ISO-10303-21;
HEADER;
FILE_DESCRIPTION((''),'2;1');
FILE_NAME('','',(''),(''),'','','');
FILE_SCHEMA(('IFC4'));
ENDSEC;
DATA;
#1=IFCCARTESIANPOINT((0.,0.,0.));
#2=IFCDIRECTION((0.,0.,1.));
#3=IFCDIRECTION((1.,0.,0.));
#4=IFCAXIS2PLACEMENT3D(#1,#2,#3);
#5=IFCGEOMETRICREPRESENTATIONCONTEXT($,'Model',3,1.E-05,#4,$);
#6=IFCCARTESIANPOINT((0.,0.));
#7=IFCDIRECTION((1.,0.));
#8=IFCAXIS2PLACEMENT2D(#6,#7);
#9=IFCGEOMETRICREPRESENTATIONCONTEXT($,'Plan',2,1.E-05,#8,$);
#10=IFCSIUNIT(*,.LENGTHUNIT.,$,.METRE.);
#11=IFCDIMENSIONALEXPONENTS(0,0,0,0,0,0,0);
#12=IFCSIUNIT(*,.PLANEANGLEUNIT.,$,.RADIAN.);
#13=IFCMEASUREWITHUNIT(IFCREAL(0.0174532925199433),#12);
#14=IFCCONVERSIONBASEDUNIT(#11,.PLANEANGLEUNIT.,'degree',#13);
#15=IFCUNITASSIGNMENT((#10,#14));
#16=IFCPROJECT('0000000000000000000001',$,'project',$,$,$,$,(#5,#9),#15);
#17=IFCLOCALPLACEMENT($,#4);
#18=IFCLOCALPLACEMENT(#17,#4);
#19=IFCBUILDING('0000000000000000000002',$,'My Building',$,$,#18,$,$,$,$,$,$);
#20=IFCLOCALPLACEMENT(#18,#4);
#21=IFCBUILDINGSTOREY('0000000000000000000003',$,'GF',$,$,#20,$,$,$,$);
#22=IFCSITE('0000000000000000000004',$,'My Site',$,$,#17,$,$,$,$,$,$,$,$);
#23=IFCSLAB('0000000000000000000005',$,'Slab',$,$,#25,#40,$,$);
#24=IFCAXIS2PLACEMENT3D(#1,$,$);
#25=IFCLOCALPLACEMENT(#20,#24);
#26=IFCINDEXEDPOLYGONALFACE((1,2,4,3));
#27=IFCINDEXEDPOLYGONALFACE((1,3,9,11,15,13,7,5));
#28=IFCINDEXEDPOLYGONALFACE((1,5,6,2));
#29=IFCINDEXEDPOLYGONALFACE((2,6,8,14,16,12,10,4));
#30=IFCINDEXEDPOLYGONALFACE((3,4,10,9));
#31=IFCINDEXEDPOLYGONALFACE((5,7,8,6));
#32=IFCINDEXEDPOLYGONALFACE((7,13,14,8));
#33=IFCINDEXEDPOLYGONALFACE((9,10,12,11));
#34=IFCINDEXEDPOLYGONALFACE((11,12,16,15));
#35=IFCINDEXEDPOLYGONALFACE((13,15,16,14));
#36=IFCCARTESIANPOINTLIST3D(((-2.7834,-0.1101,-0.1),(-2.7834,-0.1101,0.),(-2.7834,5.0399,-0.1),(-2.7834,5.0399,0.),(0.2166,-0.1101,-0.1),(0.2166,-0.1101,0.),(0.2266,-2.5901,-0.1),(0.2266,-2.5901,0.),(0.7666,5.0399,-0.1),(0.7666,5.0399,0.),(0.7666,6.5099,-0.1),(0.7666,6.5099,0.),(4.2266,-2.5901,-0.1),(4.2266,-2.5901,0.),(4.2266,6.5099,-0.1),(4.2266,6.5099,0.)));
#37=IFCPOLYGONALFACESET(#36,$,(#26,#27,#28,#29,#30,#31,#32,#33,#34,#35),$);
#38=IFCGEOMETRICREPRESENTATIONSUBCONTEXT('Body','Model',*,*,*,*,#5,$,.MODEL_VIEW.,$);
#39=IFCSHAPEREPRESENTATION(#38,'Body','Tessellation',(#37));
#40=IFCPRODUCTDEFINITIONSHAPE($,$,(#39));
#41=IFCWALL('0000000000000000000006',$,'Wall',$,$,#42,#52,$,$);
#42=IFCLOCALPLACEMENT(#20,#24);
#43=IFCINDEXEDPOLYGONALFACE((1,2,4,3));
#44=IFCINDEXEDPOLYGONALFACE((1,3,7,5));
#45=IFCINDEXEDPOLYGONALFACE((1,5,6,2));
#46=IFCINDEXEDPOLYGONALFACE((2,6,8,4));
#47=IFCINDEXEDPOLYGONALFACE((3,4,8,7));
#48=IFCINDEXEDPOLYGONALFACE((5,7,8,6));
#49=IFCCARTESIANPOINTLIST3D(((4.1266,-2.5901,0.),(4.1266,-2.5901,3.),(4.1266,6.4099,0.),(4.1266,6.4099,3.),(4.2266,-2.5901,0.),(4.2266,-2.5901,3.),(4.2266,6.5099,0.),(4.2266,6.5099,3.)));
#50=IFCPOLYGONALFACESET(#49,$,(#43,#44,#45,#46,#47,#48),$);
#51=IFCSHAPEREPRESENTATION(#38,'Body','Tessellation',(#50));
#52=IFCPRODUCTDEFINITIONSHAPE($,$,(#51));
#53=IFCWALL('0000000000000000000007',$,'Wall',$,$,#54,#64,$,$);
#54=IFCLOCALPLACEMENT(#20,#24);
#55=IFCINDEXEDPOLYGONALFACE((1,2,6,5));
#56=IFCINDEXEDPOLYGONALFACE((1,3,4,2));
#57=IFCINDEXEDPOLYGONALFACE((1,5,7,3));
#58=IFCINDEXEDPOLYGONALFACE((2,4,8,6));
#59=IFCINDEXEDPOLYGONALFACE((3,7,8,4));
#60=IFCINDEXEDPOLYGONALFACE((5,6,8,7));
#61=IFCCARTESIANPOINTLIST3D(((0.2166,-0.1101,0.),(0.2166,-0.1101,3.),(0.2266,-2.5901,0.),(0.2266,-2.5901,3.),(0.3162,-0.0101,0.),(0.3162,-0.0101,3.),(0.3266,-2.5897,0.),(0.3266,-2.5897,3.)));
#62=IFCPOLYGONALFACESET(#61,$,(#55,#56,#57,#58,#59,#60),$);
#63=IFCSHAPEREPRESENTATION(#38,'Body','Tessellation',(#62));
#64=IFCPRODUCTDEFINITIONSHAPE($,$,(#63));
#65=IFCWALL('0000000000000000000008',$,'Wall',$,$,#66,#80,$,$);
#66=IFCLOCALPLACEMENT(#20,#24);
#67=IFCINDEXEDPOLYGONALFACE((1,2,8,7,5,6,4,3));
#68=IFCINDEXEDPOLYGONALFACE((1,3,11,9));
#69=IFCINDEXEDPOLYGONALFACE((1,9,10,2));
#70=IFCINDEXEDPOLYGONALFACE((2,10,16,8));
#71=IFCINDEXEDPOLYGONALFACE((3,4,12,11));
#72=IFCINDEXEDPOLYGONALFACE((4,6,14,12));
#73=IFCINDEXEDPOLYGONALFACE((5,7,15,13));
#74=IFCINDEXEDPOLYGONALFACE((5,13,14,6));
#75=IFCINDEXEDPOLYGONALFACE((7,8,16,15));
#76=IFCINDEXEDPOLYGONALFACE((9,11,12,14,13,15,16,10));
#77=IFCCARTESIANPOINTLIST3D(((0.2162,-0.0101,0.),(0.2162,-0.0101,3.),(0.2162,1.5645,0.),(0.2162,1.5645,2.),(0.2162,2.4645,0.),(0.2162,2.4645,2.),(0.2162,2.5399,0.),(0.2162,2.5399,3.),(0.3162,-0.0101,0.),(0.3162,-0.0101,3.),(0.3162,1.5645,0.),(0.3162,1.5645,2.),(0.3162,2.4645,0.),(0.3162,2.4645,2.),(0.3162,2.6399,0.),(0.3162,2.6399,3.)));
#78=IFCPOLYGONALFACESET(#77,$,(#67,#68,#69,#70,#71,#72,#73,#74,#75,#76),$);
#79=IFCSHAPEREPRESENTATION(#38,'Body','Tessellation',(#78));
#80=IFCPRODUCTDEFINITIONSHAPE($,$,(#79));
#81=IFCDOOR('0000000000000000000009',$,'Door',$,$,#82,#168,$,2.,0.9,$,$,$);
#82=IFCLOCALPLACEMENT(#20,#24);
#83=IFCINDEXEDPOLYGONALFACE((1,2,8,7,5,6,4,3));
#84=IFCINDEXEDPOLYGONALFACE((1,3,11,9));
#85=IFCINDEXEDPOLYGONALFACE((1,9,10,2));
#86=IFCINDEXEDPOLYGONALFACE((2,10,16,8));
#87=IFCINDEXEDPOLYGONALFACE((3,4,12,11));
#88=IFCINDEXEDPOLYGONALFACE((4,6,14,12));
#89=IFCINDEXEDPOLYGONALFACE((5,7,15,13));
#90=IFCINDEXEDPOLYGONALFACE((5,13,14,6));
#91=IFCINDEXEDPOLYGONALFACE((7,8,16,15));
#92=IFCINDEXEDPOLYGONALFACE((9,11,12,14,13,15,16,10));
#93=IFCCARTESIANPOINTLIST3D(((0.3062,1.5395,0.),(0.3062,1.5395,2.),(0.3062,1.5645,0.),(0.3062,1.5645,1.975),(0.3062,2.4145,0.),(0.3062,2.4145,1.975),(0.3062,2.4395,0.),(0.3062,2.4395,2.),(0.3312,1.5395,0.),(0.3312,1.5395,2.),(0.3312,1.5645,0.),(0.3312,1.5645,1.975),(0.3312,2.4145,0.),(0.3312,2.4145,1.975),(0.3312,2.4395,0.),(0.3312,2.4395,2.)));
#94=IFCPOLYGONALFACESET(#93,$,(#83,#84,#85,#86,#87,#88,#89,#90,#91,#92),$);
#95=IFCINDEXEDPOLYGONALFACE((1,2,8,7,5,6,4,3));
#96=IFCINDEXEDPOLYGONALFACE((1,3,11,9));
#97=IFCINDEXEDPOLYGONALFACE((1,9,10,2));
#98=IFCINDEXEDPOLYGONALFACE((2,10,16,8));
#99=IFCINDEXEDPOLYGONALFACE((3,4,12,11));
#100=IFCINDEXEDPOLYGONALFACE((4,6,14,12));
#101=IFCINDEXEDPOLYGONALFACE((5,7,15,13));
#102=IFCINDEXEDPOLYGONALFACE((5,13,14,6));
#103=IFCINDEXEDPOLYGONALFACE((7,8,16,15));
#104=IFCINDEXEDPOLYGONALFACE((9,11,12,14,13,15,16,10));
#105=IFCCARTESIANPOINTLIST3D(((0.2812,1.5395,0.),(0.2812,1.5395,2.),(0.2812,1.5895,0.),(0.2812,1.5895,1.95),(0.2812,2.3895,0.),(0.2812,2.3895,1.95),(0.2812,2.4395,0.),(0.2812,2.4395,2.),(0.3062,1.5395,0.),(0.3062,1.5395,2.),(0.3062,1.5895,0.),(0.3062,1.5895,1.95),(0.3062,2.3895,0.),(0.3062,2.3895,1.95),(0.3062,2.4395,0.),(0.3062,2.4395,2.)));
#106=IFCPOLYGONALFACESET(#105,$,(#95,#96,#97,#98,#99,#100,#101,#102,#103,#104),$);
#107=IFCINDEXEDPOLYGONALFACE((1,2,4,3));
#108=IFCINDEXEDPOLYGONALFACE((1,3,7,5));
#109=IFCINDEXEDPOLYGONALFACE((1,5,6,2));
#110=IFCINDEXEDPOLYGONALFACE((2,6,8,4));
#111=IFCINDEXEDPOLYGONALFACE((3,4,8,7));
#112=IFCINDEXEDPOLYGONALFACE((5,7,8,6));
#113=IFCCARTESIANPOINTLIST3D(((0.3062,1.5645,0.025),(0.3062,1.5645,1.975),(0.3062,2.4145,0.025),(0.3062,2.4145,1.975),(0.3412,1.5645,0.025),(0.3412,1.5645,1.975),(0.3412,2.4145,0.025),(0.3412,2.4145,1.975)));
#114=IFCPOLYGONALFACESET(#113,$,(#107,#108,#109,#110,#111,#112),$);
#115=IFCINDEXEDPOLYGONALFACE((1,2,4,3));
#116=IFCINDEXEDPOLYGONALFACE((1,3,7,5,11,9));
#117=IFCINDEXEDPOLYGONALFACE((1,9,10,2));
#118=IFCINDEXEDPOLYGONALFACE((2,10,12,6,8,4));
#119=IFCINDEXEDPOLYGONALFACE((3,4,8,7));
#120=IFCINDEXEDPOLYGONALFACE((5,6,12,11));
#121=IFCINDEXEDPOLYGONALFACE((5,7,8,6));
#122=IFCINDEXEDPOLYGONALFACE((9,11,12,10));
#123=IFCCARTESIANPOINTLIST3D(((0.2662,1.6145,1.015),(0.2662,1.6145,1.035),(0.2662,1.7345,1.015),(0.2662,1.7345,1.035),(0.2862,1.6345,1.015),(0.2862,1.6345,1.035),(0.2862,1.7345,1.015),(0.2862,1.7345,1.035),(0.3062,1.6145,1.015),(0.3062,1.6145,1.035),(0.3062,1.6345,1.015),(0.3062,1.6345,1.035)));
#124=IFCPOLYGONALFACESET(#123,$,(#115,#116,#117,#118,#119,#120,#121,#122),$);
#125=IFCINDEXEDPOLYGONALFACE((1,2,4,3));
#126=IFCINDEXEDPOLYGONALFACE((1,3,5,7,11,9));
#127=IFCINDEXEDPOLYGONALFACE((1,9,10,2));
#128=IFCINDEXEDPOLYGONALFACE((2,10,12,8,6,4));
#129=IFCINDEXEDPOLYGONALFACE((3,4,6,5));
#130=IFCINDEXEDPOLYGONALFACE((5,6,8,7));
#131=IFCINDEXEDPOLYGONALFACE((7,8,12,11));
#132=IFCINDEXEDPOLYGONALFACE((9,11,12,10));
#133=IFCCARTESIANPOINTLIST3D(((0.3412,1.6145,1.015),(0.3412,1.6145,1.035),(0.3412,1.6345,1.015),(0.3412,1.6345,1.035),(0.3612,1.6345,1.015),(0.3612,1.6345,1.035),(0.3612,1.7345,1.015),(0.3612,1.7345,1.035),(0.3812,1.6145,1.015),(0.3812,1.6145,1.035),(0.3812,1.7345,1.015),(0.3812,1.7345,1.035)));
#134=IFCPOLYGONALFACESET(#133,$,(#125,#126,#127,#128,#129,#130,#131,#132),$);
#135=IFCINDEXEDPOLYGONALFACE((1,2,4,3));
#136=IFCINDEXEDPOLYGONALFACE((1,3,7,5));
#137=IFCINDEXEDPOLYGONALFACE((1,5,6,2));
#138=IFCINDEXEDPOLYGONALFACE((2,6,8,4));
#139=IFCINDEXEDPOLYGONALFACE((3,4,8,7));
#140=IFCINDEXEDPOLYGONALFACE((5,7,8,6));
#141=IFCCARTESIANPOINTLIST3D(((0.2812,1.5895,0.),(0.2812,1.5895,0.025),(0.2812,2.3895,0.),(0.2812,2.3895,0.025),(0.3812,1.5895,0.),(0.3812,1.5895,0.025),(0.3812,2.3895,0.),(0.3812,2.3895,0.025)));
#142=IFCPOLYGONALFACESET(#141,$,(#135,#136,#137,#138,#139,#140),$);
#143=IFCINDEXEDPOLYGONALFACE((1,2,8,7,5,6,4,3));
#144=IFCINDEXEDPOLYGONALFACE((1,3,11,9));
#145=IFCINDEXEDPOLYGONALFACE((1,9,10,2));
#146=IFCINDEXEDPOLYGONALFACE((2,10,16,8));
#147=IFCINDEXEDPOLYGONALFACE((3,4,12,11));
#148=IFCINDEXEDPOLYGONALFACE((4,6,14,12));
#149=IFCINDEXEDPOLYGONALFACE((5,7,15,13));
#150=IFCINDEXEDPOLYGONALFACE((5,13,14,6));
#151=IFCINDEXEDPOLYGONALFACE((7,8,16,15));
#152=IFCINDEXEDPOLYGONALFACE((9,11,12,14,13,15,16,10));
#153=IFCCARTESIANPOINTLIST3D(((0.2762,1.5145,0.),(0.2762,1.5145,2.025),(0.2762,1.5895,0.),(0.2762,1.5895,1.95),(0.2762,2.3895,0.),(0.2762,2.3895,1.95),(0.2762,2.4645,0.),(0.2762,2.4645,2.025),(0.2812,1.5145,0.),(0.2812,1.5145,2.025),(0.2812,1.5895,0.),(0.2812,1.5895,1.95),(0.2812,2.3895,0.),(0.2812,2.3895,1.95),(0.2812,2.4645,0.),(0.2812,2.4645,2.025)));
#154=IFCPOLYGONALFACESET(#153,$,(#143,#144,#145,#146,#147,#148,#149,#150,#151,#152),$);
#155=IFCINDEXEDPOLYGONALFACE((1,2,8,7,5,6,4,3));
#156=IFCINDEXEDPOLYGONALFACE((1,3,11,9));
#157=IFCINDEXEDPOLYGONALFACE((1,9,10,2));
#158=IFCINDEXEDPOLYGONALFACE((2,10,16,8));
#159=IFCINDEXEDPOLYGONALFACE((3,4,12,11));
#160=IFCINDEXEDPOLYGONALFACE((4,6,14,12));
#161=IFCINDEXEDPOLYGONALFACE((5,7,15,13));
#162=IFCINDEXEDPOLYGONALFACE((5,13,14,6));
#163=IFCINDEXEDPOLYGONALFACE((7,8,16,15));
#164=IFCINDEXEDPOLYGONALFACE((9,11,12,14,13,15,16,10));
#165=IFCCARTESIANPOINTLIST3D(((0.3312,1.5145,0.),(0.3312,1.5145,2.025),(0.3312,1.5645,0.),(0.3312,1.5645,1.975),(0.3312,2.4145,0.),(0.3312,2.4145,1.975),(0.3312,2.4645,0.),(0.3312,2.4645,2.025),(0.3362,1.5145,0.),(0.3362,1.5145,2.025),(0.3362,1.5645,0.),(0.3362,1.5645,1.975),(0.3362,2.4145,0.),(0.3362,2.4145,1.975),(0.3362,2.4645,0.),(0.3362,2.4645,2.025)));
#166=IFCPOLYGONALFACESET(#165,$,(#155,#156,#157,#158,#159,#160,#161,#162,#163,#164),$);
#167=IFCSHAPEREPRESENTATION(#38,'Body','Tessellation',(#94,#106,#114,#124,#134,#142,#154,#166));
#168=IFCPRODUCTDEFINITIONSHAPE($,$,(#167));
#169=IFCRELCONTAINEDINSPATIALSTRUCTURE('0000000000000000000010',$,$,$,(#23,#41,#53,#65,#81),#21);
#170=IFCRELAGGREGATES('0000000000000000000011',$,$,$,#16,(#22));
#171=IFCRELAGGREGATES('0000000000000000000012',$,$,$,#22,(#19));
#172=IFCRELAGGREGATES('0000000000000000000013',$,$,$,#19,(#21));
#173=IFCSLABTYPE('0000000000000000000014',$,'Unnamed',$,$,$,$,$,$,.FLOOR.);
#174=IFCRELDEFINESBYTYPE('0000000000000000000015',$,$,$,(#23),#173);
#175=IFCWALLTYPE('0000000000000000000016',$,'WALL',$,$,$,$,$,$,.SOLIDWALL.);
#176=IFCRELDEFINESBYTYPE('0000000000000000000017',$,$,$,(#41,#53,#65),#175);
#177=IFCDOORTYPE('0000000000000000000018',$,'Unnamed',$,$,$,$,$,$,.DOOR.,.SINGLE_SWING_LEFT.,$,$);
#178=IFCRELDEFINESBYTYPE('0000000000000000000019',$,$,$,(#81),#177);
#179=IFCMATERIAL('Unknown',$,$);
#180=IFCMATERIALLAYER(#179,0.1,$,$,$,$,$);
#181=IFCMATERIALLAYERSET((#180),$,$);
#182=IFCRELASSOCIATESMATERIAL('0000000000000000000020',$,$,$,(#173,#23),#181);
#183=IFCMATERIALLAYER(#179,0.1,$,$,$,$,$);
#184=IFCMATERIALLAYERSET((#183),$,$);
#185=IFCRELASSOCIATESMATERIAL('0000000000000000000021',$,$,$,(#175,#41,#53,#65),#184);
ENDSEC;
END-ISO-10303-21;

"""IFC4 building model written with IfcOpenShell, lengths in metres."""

from ifc_helpers import new_model, entity, si_unit, converted_unit, frame, origin_with_axes, origin_2d_with_axis, place, context, subcontext, project, spatial, line, indexed_curve, outline, extrude, shape, source, transform, mapped, material, layer, layer_set, layer_usage, type_object, type_shapes, element, fill, save


model = new_model("IFC4")

# Units and contexts
model_context = context("Model", 3, precision=1e-05, world=origin_with_axes())
plan_context = context("Plan", 2, precision=1e-05, world=origin_2d_with_axis())
body_context_1 = subcontext(model_context, "Body", "Model", "MODEL_VIEW")
body_context_2 = subcontext(plan_context, "Body", "Plan", "PLAN_VIEW")
ifc_project = project(units=[si_unit("LENGTHUNIT", "METRE"), converted_unit("PLANEANGLEUNIT", "degree", entity("IfcReal", 0.0174532925199433), si_unit("PLANEANGLEUNIT", "RADIAN"), dimensions=[0, 0, 0, 0, 0, 0, 0])], contexts=[model_context, plan_context])

# Site, building, storey
site_placement = place(None, origin_with_axes())
site = spatial("IfcSite", under=ifc_project, at=site_placement, Name="My Site")
building_placement = place(site_placement, origin_with_axes())
building = spatial("IfcBuilding", under=site, at=building_placement, Name="My Building")
storey_placement = place(building_placement, origin_with_axes())
storey = spatial("IfcBuildingStorey", under=building, at=storey_placement, Name="GF")

# Slab
ifc_material = material(Name="Unknown")
ifc_layer_1 = layer(ifc_material, 0.1)
ifc_layer_set_1 = layer_set([ifc_layer_1])
ifc_layer_usage_1 = layer_usage(ifc_layer_set_1, "AXIS3", "POSITIVE", -0.1)
slab_type = type_object("IfcSlabType", Name="Unnamed", PredefinedType="FLOOR", material=ifc_layer_set_1)
slab_placement = place(storey_placement, frame((4.2266, -2.5901, 0.0), z_axis=(0.0, 0.0, 1.0), x_axis=(1.0, 0.0, 0.0)))
element("IfcSlab", 1, at=slab_placement, inside=storey, type_object=slab_type, material=ifc_layer_usage_1, Name="Slab", context=body_context_1, shape_type="SweptSolid", body=[
    extrude(outline(indexed_curve([(0.0, 0.0), (0.0, 9.1), (-3.46, 9.1), (-3.46, 7.63), (-7.01, 7.63), (-7.01, 2.48), (-4.01, 2.48), (-4.0, 0.0), (0.0, 0.0)])), frame((0.0, 0.0, -0.1), z_axis=(0.0, 0.0, 1.0), x_axis=(1.0, 0.0, 0.0)), (0.0, 0.0, 1.0), 0.1),
])

# Shared definitions
ifc_layer_2 = layer(ifc_material, 0.1)
ifc_layer_set_2 = layer_set([ifc_layer_2])
wall_type = type_object("IfcWallType", Name="WALL", PredefinedType="SOLIDWALL", material=ifc_layer_set_2)
shared_shape_1 = source(origin_with_axes(), body_context_1, "Body", "SweptSolid", [
    extrude(outline(indexed_curve([(0.0, 0.0), (0.9, 0.0), (0.9, 2.0), (0.0, 2.0)], segments=[line(1, 2, 3, 4, 1)])), frame((0.0, -0.6, 0.0), z_axis=(0.0, -1.0, 0.0), x_axis=(1.0, 0.0, 0.0)), (0.0, 0.0, -1.0), 1.2),
])
door_type = type_object("IfcDoorType", Name="Unnamed", OperationType="SINGLE_SWING_LEFT", PredefinedType="DOOR")
shared_shape_2 = source(origin_with_axes(), body_context_1, "Body", "SweptSolid", [
    extrude(outline(indexed_curve([(0.0, 0.0), (0.0, 2.0), (0.9, 2.0), (0.9, 0.0), (0.875, 0.0), (0.875, 1.975), (0.025, 1.975), (0.025, 0.0)], segments=[line(1, 2, 3, 4, 5, 6, 7, 8, 1)])), frame((0.0, 0.025, 0.0), z_axis=(0.0, -1.0, 0.0), x_axis=(1.0, 0.0, 0.0)), (0.0, 0.0, -1.0), 0.025),
    extrude(outline(indexed_curve([(0.0, 0.0), (0.0, 2.0), (0.9, 2.0), (0.9, 0.0), (0.85, 0.0), (0.85, 1.95), (0.05, 1.95), (0.05, 0.0)], segments=[line(1, 2, 3, 4, 5, 6, 7, 8, 1)])), frame((0.0, 0.0, 0.0), z_axis=(0.0, -1.0, 0.0), x_axis=(1.0, 0.0, 0.0)), (0.0, 0.0, -1.0), 0.025),
    extrude(outline(indexed_curve([(0.0, 0.0), (0.85, 0.0), (0.85, 0.035), (0.0, 0.035)], segments=[line(1, 2, 3, 4, 1)])), frame((0.025, 0.025, 0.025), z_axis=(0.0, 0.0, 1.0), x_axis=(1.0, 0.0, 0.0)), (0.0, 0.0, 1.0), 1.95),
    extrude(outline(indexed_curve([(0.0, 0.0), (0.0, -0.04), (-0.12, -0.04), (-0.12, -0.02), (-0.02, -0.02), (-0.02, 0.0)], segments=[line(1, 2, 3, 4, 5, 6, 1)])), frame((0.825, 0.025, 1.015), z_axis=(0.0, 0.0, 1.0), x_axis=(1.0, 0.0, 0.0)), (0.0, 0.0, 1.0), 0.02),
    extrude(outline(indexed_curve([(0.0, 0.0), (0.0, 0.04), (-0.12, 0.04), (-0.12, 0.02), (-0.02, 0.02), (-0.02, 0.0)], segments=[line(1, 2, 3, 4, 5, 6, 1)])), frame((0.825, 0.06, 1.015), z_axis=(0.0, 0.0, 1.0), x_axis=(1.0, 0.0, 0.0)), (0.0, 0.0, 1.0), 0.02),
    extrude(outline(indexed_curve([(0.0, 0.0), (0.8, 0.0), (0.8, 0.1), (0.0, 0.1)], segments=[line(1, 2, 3, 4, 1)])), frame((0.05, 0.0, 0.0), z_axis=(0.0, 0.0, 1.0), x_axis=(1.0, 0.0, 0.0)), (0.0, 0.0, 1.0), 0.025),
    extrude(outline(indexed_curve([(0.0, 0.0), (0.0, 2.025), (0.95, 2.025), (0.95, 0.0), (0.875, 0.0), (0.875, 1.95), (0.075, 1.95), (0.075, 0.0)], segments=[line(1, 2, 3, 4, 5, 6, 7, 8, 1)])), frame((-0.025, -0.005, 0.0), z_axis=(0.0, -1.0, 0.0), x_axis=(1.0, 0.0, 0.0)), (0.0, 0.0, -1.0), 0.005),
    extrude(outline(indexed_curve([(0.0, 0.0), (0.0, 2.025), (0.95, 2.025), (0.95, 0.0), (0.9, 0.0), (0.9, 1.975), (0.05, 1.975), (0.05, 0.0)], segments=[line(1, 2, 3, 4, 5, 6, 7, 8, 1)])), frame((-0.025, 0.05, 0.0), z_axis=(0.0, -1.0, 0.0), x_axis=(1.0, 0.0, 0.0)), (0.0, 0.0, -1.0), 0.005),
])
shared_shape_3 = source(origin_with_axes(), body_context_2, "Body", "Curve2D", [
    entity("IfcIndexedPolyCurve", entity("IfcCartesianPointList2D", [[0.0, 0.0], [0.0, 0.05], [0.025, 0.05], [0.025, 0.025], [0.05, 0.025], [0.05, 0.0]]), [entity("IfcLineIndex", [1, 2, 3, 4, 5, 6, 1])]),
    entity("IfcIndexedPolyCurve", entity("IfcCartesianPointList2D", [[0.9, 0.0], [0.9, 0.05], [0.875, 0.05], [0.875, 0.025], [0.85, 0.025], [0.85, 0.0]]), [entity("IfcLineIndex", [1, 2, 3, 4, 5, 6, 1])]),
    entity("IfcTrimmedCurve", entity("IfcEllipse", entity("IfcAxis2Placement2D", entity("IfcCartesianPoint", [0.06, 0.05]), entity("IfcDirection", [1.0, 0.0])), 0.815, 0.85), [entity("IfcCartesianPoint", [0.875, 0.05])], [entity("IfcCartesianPoint", [0.06, 0.9])], True, "CARTESIAN"),
    entity("IfcIndexedPolyCurve", entity("IfcCartesianPointList2D", [[0.025, 0.05], [0.06, 0.05], [0.06, 0.9], [0.025, 0.9]]), [entity("IfcLineIndex", [1, 2, 3, 4, 1])]),
])
type_shapes(door_type, [shared_shape_2, shared_shape_3])

# Wall
ifc_layer_usage_2 = layer_usage(ifc_layer_set_2, "AXIS2", "POSITIVE", 0.0)
wall_1_placement = place(storey_placement, frame((4.2266, -2.5901, 0.0), z_axis=(0.0, 0.0, 1.0), x_axis=(0.0, 1.0, 0.0)))
element("IfcWall", 2, at=wall_1_placement, inside=storey, type_object=wall_type, material=ifc_layer_usage_2, Name="Wall", context=body_context_1, shape_type="SweptSolid", body=[
    extrude(outline(indexed_curve([(0.0, 0.0), (0.0, 0.1), (9.0, 0.1), (9.1, 0.0)], segments=[line(1, 2, 3, 4, 1)])), origin_with_axes(), (0.0, 0.0, 1.0), 3.0),
])

# Wall
ifc_layer_usage_3 = layer_usage(ifc_layer_set_2, "AXIS2", "POSITIVE", 0.0)
wall_2_placement = place(storey_placement, frame((0.2166, -0.1101, 0.0), z_axis=(0.0, 0.0, 1.0), x_axis=(0.004032, -0.999992, 0.0)))
element("IfcWall", 3, at=wall_2_placement, inside=storey, type_object=wall_type, material=ifc_layer_usage_3, Name="Wall", context=body_context_1, shape_type="SweptSolid", body=[
    extrude(outline(indexed_curve([(0.0, 0.0), (-0.0996, 0.1), (2.48, 0.1), (2.48, 0.0)], segments=[line(1, 2, 3, 4, 1)])), origin_with_axes(), (0.0, 0.0, 1.0), 3.0),
])

# Wall, opening, door
ifc_layer_usage_4 = layer_usage(ifc_layer_set_2, "AXIS2", "POSITIVE", 0.0)
wall_3_placement = place(storey_placement, frame((0.3162, -0.0101, 0.0), z_axis=(0.0, 0.0, 1.0), x_axis=(0.0, 1.0, 0.0)))
wall_3 = element("IfcWall", 4, at=wall_3_placement, inside=storey, type_object=wall_type, material=ifc_layer_usage_4, Name="Wall", context=body_context_1, shape_type="SweptSolid", body=[
    extrude(outline(indexed_curve([(0.0, 0.0), (0.0, 0.1), (2.55, 0.1), (2.65, 0.0)], segments=[line(1, 2, 3, 4, 1)])), origin_with_axes(), (0.0, 0.0, 1.0), 3.0),
])
opening_1_placement = place(wall_3_placement, frame((1.5746, 0.0, 0.0), z_axis=(0.0, 0.0, 1.0), x_axis=(1.0, 0.0, 0.0)))
opening_1 = element("IfcOpeningElement", 5, at=opening_1_placement, cuts=wall_3, PredefinedType="OPENING", context=body_context_1, shape_type="MappedRepresentation", body=[
    mapped(shared_shape_1, transform((0.0, 0.0, 0.0), x_axis=(1.0, 0.0, 0.0), y_axis=(0.0, 1.0, 0.0), z_axis=(0.0, 0.0, 1.0), scale=1.0)),
])
door_1_placement = place(opening_1_placement, frame((0.875, 0.035, 0.0), z_axis=(0.0, 0.0, 1.0), x_axis=(-1.0, 0.0, 0.0)))
door_1 = element("IfcDoor", 6, at=door_1_placement, inside=storey, type_object=door_type, Name="Door", OverallHeight=2.0, OverallWidth=0.9, shapes=[
    shape(body_context_1, "Body", "MappedRepresentation", [mapped(shared_shape_2, transform((0.0, 0.0, 0.0), x_axis=(1.0, 0.0, 0.0), y_axis=(0.0, 1.0, 0.0), z_axis=(0.0, 0.0, 1.0), scale=1.0))]),
    shape(body_context_2, "Body", "MappedRepresentation", [mapped(shared_shape_3, transform((0.0, 0.0, 0.0), x_axis=(1.0, 0.0, 0.0), y_axis=(0.0, 1.0, 0.0), z_axis=(0.0, 0.0, 1.0), scale=1.0))]),
])
fill(opening_1, door_1)

save(model, "model.ifc")
